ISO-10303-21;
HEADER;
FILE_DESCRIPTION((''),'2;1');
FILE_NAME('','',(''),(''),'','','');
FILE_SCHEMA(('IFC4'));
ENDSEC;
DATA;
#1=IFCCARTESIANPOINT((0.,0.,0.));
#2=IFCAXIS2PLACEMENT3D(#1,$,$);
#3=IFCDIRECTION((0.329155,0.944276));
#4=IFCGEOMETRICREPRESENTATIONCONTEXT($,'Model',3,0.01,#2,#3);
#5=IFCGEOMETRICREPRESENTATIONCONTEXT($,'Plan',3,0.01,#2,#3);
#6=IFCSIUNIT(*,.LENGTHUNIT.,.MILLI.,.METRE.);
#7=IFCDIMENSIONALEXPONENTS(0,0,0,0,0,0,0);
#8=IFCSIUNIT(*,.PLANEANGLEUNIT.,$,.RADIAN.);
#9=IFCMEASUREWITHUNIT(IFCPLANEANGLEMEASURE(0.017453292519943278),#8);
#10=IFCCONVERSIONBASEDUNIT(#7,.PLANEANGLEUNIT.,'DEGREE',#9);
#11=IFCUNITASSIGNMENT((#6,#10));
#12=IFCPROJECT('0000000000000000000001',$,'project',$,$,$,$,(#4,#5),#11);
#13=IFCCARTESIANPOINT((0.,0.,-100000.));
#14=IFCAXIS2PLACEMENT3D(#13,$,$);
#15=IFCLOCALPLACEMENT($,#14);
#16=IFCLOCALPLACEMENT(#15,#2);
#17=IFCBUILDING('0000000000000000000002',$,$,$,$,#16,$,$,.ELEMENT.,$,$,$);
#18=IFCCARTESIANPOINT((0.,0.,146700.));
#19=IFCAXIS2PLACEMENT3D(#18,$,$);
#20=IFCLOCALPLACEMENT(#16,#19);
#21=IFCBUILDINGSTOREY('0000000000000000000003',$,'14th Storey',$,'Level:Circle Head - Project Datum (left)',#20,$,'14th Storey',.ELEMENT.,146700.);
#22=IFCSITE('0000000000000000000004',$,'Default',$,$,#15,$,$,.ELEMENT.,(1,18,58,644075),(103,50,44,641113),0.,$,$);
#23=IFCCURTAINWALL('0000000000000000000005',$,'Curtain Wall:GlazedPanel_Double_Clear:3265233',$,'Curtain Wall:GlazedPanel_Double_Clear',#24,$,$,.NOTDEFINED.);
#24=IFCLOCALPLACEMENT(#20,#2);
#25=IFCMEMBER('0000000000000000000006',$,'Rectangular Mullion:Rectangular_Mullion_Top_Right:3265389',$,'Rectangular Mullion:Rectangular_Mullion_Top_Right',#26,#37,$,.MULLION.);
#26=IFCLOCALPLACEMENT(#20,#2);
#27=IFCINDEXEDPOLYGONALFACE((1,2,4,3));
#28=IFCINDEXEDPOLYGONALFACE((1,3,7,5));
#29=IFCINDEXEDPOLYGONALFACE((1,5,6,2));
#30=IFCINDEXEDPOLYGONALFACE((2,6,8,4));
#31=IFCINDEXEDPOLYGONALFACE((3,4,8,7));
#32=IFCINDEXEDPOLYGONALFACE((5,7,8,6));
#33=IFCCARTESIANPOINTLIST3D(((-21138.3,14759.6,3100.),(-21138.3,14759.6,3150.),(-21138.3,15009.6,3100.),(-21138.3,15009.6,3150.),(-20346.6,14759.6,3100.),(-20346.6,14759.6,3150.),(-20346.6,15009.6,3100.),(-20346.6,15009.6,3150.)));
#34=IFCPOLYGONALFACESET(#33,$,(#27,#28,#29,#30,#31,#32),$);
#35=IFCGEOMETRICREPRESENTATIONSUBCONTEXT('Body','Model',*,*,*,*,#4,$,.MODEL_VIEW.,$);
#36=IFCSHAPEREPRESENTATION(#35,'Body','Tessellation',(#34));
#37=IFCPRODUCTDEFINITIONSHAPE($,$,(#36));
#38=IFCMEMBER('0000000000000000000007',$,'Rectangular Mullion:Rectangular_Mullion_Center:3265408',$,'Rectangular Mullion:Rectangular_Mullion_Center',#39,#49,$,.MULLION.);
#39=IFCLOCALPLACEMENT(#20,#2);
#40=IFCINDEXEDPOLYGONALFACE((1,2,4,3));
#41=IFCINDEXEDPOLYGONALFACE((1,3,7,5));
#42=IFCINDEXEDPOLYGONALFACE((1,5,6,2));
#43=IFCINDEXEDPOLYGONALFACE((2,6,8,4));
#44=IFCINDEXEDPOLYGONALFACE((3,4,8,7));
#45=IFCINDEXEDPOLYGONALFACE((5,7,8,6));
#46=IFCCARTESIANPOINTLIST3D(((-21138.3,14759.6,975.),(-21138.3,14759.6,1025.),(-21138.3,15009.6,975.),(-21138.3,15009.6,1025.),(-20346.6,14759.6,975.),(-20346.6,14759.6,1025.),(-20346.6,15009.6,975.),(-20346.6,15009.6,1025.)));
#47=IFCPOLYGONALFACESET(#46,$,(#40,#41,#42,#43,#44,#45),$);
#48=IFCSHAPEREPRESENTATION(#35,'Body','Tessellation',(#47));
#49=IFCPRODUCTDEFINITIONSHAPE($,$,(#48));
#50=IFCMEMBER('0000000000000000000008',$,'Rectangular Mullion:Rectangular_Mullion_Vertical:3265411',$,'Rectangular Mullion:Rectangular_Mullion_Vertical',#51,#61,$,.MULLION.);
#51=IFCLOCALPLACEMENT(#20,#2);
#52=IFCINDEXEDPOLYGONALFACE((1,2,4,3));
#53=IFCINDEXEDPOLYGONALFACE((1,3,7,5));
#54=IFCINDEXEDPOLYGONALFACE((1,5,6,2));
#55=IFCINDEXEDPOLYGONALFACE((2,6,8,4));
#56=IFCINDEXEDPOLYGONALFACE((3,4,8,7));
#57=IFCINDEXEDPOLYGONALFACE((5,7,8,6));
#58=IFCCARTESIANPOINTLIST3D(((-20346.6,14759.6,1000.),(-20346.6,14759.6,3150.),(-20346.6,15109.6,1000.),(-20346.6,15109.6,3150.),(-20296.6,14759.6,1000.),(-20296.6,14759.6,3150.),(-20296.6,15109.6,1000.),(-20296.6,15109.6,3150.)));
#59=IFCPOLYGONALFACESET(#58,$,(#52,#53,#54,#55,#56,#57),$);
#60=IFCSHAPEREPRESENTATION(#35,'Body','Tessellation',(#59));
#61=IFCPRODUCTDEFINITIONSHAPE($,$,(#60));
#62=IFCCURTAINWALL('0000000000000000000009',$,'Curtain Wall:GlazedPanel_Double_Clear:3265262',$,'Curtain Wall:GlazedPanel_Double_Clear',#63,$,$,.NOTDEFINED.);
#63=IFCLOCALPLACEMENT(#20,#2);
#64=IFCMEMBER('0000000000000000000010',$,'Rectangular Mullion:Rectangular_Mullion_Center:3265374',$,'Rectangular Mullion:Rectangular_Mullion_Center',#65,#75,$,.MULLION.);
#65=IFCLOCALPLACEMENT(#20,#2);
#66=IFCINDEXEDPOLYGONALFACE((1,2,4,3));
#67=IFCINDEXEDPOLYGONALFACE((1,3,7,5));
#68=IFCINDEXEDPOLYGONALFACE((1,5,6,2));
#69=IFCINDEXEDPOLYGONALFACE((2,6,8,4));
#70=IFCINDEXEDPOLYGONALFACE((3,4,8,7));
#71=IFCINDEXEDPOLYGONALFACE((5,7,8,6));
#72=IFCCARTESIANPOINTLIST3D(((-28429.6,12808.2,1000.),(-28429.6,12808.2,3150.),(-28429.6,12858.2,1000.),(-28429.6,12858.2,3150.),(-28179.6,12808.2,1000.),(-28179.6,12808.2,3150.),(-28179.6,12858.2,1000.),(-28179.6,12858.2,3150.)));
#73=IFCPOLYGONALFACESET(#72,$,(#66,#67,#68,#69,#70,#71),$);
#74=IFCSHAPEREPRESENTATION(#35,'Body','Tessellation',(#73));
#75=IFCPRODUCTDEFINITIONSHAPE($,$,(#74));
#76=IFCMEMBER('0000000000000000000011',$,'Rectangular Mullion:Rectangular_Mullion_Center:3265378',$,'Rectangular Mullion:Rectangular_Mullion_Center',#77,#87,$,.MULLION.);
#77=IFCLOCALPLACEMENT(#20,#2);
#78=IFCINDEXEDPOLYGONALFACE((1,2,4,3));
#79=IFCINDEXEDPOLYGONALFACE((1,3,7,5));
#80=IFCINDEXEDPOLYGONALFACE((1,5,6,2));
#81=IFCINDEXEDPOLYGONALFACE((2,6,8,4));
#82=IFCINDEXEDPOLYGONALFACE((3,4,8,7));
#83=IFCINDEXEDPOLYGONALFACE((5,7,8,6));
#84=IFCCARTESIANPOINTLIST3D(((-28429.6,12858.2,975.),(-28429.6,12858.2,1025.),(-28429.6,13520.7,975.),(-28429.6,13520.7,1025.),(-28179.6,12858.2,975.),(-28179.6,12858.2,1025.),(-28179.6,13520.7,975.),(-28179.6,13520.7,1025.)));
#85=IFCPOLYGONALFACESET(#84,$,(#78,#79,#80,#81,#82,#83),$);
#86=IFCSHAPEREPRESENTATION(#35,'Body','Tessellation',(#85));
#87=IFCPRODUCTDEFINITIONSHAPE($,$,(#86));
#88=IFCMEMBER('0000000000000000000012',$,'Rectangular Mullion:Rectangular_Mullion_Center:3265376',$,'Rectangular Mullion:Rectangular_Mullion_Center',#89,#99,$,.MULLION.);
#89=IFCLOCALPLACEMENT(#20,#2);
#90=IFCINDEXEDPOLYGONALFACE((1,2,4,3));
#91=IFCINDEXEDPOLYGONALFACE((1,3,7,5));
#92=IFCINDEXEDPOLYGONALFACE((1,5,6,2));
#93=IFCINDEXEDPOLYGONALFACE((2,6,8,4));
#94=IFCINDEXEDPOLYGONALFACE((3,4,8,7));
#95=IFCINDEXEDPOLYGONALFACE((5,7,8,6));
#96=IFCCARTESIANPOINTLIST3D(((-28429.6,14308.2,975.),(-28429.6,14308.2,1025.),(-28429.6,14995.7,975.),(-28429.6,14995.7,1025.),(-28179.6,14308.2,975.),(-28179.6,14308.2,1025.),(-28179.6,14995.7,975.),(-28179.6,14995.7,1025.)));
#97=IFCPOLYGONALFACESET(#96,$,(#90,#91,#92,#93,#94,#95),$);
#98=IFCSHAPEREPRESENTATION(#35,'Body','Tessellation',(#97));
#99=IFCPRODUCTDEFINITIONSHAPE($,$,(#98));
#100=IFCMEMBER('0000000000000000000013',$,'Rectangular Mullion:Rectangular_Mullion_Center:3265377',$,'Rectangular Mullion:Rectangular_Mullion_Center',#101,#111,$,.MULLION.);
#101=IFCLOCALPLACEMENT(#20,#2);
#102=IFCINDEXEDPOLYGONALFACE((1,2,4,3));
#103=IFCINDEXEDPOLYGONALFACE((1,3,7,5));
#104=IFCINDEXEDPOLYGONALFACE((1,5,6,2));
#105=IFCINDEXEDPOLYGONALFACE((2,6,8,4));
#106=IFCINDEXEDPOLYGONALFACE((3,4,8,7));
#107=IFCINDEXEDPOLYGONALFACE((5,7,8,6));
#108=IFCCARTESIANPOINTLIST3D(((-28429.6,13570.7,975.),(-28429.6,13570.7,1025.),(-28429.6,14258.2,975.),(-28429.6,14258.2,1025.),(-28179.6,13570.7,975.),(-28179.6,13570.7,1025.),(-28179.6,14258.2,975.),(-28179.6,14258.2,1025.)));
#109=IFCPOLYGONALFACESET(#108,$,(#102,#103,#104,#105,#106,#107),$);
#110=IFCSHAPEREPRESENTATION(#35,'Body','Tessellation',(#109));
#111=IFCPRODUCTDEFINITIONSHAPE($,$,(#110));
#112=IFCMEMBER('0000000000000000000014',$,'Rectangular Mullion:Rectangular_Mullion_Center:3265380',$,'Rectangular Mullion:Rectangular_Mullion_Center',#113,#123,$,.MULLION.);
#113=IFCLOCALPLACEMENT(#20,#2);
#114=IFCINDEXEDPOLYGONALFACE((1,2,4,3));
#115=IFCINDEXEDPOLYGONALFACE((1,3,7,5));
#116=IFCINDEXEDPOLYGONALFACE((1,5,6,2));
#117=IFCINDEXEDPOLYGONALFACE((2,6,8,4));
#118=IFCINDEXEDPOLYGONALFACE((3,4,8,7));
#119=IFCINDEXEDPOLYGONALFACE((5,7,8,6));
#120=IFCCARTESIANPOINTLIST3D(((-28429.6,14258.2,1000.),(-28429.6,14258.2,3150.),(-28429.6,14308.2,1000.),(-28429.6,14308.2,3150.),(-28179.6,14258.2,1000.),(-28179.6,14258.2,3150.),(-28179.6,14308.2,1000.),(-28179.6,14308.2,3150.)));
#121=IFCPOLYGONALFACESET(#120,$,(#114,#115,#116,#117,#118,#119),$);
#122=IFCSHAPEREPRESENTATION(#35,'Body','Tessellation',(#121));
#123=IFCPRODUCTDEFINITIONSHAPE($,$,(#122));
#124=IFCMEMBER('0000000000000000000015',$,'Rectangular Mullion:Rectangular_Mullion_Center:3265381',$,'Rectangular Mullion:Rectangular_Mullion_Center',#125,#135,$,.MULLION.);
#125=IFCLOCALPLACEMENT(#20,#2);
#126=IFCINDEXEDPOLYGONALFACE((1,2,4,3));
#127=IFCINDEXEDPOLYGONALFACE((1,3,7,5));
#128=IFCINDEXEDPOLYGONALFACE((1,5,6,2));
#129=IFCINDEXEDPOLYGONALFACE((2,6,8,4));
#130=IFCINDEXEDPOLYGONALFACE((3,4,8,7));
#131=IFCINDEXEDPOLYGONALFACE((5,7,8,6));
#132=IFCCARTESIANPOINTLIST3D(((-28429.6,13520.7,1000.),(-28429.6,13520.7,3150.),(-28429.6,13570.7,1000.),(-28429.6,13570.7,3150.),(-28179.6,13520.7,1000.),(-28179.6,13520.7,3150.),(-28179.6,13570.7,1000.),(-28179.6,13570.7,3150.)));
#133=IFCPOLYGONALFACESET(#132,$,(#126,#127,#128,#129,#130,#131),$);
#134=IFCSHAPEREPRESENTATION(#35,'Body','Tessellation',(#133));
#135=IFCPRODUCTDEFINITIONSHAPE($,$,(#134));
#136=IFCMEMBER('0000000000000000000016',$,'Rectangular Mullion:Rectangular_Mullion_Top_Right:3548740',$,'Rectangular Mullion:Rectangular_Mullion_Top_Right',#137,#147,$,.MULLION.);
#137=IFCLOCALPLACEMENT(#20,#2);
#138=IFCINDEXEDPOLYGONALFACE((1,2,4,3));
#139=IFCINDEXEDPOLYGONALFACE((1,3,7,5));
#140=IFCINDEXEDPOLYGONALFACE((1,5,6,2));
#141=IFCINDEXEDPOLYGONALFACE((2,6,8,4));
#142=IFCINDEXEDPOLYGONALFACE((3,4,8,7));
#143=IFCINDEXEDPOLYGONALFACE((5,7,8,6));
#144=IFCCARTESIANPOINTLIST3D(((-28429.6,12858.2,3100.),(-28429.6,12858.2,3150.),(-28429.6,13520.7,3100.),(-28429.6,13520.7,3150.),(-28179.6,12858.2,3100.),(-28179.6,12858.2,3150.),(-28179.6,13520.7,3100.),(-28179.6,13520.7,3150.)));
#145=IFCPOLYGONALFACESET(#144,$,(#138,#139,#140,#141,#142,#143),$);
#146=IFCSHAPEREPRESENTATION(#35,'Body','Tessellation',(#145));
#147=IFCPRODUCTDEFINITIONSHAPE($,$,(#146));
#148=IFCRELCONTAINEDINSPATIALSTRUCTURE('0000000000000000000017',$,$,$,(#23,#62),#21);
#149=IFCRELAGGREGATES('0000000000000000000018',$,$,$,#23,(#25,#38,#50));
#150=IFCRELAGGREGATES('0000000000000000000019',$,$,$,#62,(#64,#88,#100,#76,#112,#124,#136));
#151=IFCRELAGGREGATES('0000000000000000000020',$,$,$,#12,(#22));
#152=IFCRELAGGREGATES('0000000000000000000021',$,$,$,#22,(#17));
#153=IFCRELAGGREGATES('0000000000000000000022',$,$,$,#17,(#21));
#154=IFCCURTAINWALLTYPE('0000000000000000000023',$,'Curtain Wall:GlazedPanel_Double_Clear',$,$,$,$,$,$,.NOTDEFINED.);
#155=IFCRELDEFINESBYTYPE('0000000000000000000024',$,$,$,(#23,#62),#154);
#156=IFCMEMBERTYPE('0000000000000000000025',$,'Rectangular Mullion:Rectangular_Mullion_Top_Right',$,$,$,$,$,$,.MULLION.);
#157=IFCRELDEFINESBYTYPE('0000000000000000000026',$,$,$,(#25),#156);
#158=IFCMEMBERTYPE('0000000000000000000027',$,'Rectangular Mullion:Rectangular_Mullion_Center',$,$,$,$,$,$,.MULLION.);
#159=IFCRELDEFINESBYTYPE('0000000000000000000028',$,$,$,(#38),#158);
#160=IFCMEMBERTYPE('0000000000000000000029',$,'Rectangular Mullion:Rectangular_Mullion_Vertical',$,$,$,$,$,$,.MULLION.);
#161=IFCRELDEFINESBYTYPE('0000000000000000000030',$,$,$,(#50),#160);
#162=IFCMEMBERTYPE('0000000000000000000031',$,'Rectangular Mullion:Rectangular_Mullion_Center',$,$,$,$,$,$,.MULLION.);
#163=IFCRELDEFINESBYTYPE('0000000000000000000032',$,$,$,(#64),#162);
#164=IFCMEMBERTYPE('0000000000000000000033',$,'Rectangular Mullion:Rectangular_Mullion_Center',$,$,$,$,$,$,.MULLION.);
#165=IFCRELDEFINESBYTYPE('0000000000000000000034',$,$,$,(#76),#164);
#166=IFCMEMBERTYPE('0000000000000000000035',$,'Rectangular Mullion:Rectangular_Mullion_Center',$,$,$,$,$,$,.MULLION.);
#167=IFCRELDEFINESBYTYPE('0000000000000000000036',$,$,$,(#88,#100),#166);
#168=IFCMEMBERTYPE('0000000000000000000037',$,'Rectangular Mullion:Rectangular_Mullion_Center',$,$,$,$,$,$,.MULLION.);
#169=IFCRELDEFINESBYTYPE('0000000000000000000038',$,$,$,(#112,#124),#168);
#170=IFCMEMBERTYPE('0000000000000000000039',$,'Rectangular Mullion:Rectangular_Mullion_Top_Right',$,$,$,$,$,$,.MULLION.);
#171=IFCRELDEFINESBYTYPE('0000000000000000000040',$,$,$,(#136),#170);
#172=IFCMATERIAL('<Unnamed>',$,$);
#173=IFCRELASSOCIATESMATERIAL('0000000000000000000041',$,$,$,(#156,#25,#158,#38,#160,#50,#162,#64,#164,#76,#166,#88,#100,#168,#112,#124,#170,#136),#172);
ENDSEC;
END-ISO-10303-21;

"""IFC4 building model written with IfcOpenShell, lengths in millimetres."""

from ifc_helpers import new_model, entity, si_unit, converted_unit, direction, frame, origin, place, context, subcontext, project, spatial, indexed_curve, outline, extrude, source, transform, mapped, material, type_object, type_shapes, element, aggregate, save


model = new_model("IFC4")

# Units and contexts
model_context = context("Model", 3, precision=0.01, world=origin(), true_north=direction((0.329155, 0.944276)))
plan_context = context("Plan", 3, precision=0.01, world=origin(), true_north=direction((0.329155, 0.944276)))
body_context = subcontext(model_context, "Body", "Model", "MODEL_VIEW")
ifc_project = project(units=[si_unit("LENGTHUNIT", "METRE", prefix="MILLI"), converted_unit("PLANEANGLEUNIT", "DEGREE", entity("IfcPlaneAngleMeasure", 0.017453292519943278), si_unit("PLANEANGLEUNIT", "RADIAN"), dimensions=[0, 0, 0, 0, 0, 0, 0])], contexts=[model_context, plan_context])

# Site, building, storey
site_placement = place(None, frame((0.0, 0.0, -100000.0)))
site = spatial("IfcSite", under=ifc_project, at=site_placement, Name="Default", CompositionType="ELEMENT", RefLatitude=(1, 18, 58, 644075), RefLongitude=(103, 50, 44, 641113), RefElevation=0.0)
building_placement = place(site_placement, origin())
building = spatial("IfcBuilding", under=site, at=building_placement, CompositionType="ELEMENT")
storey_placement = place(building_placement, frame((0.0, 0.0, 146700.0)))
storey = spatial("IfcBuildingStorey", under=building, at=storey_placement, Name="14th Storey", ObjectType="Level:Circle Head - Project Datum (left)", LongName="14th Storey", CompositionType="ELEMENT", Elevation=146700.0)

# Curtain walls, members
curtain_wall_type = type_object("IfcCurtainWallType", Name="Curtain Wall:GlazedPanel_Double_Clear", PredefinedType="NOTDEFINED")
curtain_wall_1_placement = place(storey_placement, frame((0.0, 0.0, -146700.0)))
curtain_wall_1 = element("IfcCurtainWall", 1, at=curtain_wall_1_placement, inside=storey, type_object=curtain_wall_type, Name="Curtain Wall:GlazedPanel_Double_Clear:3265233", ObjectType="Curtain Wall:GlazedPanel_Double_Clear", PredefinedType="NOTDEFINED")
ifc_material_1 = material(Name="<Unnamed>")
member_type_1 = type_object("IfcMemberType", Name="Rectangular Mullion:Rectangular_Mullion_Top_Right", PredefinedType="MULLION", material=ifc_material_1)
shared_shape_1 = source(origin(), body_context, "Body", "SweptSolid", [
    extrude(outline(indexed_curve([(-25.0, -125.0), (25.0, -125.0), (25.0, 125.0), (-25.0, 125.0), (-25.0, -125.0)], self_intersect=False)), frame((-25.0, 0.0, -791.6), z_axis=(0.0, 0.0, 1.0), x_axis=(-1.0, 0.0, 0.0)), (0.0, 0.0, 1.0), 791.6),
])
type_shapes(member_type_1, [shared_shape_1])
member_1_placement = place(curtain_wall_1_placement, frame((-20346.6, 14884.6, 149850.0), z_axis=(1.0, 0.0, 0.0), x_axis=(0.0, 0.0, 1.0)))
member_1 = element("IfcMember", 2, at=member_1_placement, type_object=member_type_1, material=ifc_material_1, Name="Rectangular Mullion:Rectangular_Mullion_Top_Right:3265389", ObjectType="Rectangular Mullion:Rectangular_Mullion_Top_Right", PredefinedType="MULLION", context=body_context, shape_type="MappedRepresentation", body=[
    mapped(shared_shape_1, transform((0.0, 0.0, 0.0), scale=1.0)),
])
member_type_2 = type_object("IfcMemberType", Name="Rectangular Mullion:Rectangular_Mullion_Center", PredefinedType="MULLION", material=ifc_material_1)
shared_shape_2 = source(origin(), body_context, "Body", "SweptSolid", [
    extrude(outline(indexed_curve([(-25.0, -125.0), (25.0, -125.0), (25.0, 125.0), (-25.0, 125.0), (-25.0, -125.0)], self_intersect=False)), frame((0.0, 0.0, -791.7), z_axis=(0.0, 0.0, 1.0), x_axis=(-1.0, 0.0, 0.0)), (0.0, 0.0, 1.0), 791.7),
])
type_shapes(member_type_2, [shared_shape_2])
member_2_placement = place(curtain_wall_1_placement, frame((-20346.6, 14884.6, 147700.0), z_axis=(1.0, 0.0, 0.0), x_axis=(0.0, 0.0, 1.0)))
member_2 = element("IfcMember", 3, at=member_2_placement, type_object=member_type_2, material=ifc_material_1, Name="Rectangular Mullion:Rectangular_Mullion_Center:3265408", ObjectType="Rectangular Mullion:Rectangular_Mullion_Center", PredefinedType="MULLION", context=body_context, shape_type="MappedRepresentation", body=[
    mapped(shared_shape_2, transform((0.0, 0.0, 0.0), scale=1.0)),
])
member_type_3 = type_object("IfcMemberType", Name="Rectangular Mullion:Rectangular_Mullion_Vertical", PredefinedType="MULLION", material=ifc_material_1)
shared_shape_3 = source(origin(), body_context, "Body", "SweptSolid", [
    extrude(outline(indexed_curve([(-25.0, -175.0), (25.0, -175.0), (25.0, 175.0), (-25.0, 175.0), (-25.0, -175.0)], self_intersect=False)), frame((0.0, -50.0, -2150.0), z_axis=(0.0, 0.0, 1.0), x_axis=(-1.0, 0.0, 0.0)), (0.0, 0.0, 1.0), 2150.0),
])
type_shapes(member_type_3, [shared_shape_3])
member_3_placement = place(curtain_wall_1_placement, frame((-20321.6, 14884.6, 147700.0), z_axis=(0.0, 0.0, -1.0), x_axis=(1.0, 0.0, 0.0)))
member_3 = element("IfcMember", 4, at=member_3_placement, type_object=member_type_3, material=ifc_material_1, Name="Rectangular Mullion:Rectangular_Mullion_Vertical:3265411", ObjectType="Rectangular Mullion:Rectangular_Mullion_Vertical", PredefinedType="MULLION", context=body_context, shape_type="MappedRepresentation", body=[
    mapped(shared_shape_3, transform((0.0, 0.0, 0.0), scale=1.0)),
])
aggregate(curtain_wall_1, [member_1, member_2, member_3])
curtain_wall_2_placement = place(storey_placement, frame((0.0, 0.0, -146700.0)))
curtain_wall_2 = element("IfcCurtainWall", 5, at=curtain_wall_2_placement, inside=storey, type_object=curtain_wall_type, Name="Curtain Wall:GlazedPanel_Double_Clear:3265262", ObjectType="Curtain Wall:GlazedPanel_Double_Clear", PredefinedType="NOTDEFINED")
member_type_4 = type_object("IfcMemberType", Name="Rectangular Mullion:Rectangular_Mullion_Center", PredefinedType="MULLION", material=ifc_material_1)
shared_shape_4 = source(origin(), body_context, "Body", "SweptSolid", [
    extrude(outline(indexed_curve([(-25.0, -125.0), (25.0, -125.0), (25.0, 125.0), (-25.0, 125.0), (-25.0, -125.0)], self_intersect=False)), frame((-25.0, 0.0, -2150.0), z_axis=(0.0, 0.0, 1.0), x_axis=(-1.0, 0.0, 0.0)), (0.0, 0.0, 1.0), 2150.0),
])
type_shapes(member_type_4, [shared_shape_4])
member_4_placement = place(curtain_wall_2_placement, frame((-28304.6, 12808.2, 147700.0), z_axis=(0.0, 0.0, -1.0), x_axis=(0.0, -1.0, 0.0)))
member_4 = element("IfcMember", 6, at=member_4_placement, type_object=member_type_4, material=ifc_material_1, Name="Rectangular Mullion:Rectangular_Mullion_Center:3265374", ObjectType="Rectangular Mullion:Rectangular_Mullion_Center", PredefinedType="MULLION", context=body_context, shape_type="MappedRepresentation", body=[
    mapped(shared_shape_4, transform((0.0, 0.0, 0.0), scale=1.0)),
])
member_type_5 = type_object("IfcMemberType", Name="Rectangular Mullion:Rectangular_Mullion_Center", PredefinedType="MULLION", material=ifc_material_1)
shared_shape_5 = source(origin(), body_context, "Body", "SweptSolid", [
    extrude(outline(indexed_curve([(-25.0, -125.0), (25.0, -125.0), (25.0, 125.0), (-25.0, 125.0), (-25.0, -125.0)], self_intersect=False)), frame((0.0, 0.0, -662.5), z_axis=(0.0, 0.0, 1.0), x_axis=(-1.0, 0.0, 0.0)), (0.0, 0.0, 1.0), 662.5),
])
type_shapes(member_type_5, [shared_shape_5])
member_5_placement = place(curtain_wall_2_placement, frame((-28304.6, 12858.2, 147700.0), z_axis=(0.0, -1.0, 0.0), x_axis=(0.0, 0.0, 1.0)))
member_5 = element("IfcMember", 7, at=member_5_placement, type_object=member_type_5, material=ifc_material_1, Name="Rectangular Mullion:Rectangular_Mullion_Center:3265378", ObjectType="Rectangular Mullion:Rectangular_Mullion_Center", PredefinedType="MULLION", context=body_context, shape_type="MappedRepresentation", body=[
    mapped(shared_shape_5, transform((0.0, 0.0, 0.0), scale=1.0)),
])
member_type_6 = type_object("IfcMemberType", Name="Rectangular Mullion:Rectangular_Mullion_Center", PredefinedType="MULLION", material=ifc_material_1)
shared_shape_6 = source(origin(), body_context, "Body", "SweptSolid", [
    extrude(outline(indexed_curve([(-25.0, -125.0), (25.0, -125.0), (25.0, 125.0), (-25.0, 125.0), (-25.0, -125.0)], self_intersect=False)), frame((0.0, 0.0, -687.5), z_axis=(0.0, 0.0, 1.0), x_axis=(-1.0, 0.0, 0.0)), (0.0, 0.0, 1.0), 687.5),
])
type_shapes(member_type_6, [shared_shape_6])
member_6_placement = place(curtain_wall_2_placement, frame((-28304.6, 14308.2, 147700.0), z_axis=(0.0, -1.0, 0.0), x_axis=(0.0, 0.0, 1.0)))
member_6 = element("IfcMember", 8, at=member_6_placement, type_object=member_type_6, material=ifc_material_1, Name="Rectangular Mullion:Rectangular_Mullion_Center:3265376", ObjectType="Rectangular Mullion:Rectangular_Mullion_Center", PredefinedType="MULLION", context=body_context, shape_type="MappedRepresentation", body=[
    mapped(shared_shape_6, transform((0.0, 0.0, 0.0), scale=1.0)),
])
member_7_placement = place(curtain_wall_2_placement, frame((-28304.6, 13570.7, 147700.0), z_axis=(0.0, -1.0, 0.0), x_axis=(0.0, 0.0, 1.0)))
member_7 = element("IfcMember", 9, at=member_7_placement, type_object=member_type_6, material=ifc_material_1, Name="Rectangular Mullion:Rectangular_Mullion_Center:3265377", ObjectType="Rectangular Mullion:Rectangular_Mullion_Center", PredefinedType="MULLION", context=body_context, shape_type="MappedRepresentation", body=[
    mapped(shared_shape_6, transform((0.0, 0.0, 0.0), scale=1.0)),
])
member_type_7 = type_object("IfcMemberType", Name="Rectangular Mullion:Rectangular_Mullion_Center", PredefinedType="MULLION", material=ifc_material_1)
shared_shape_7 = source(origin(), body_context, "Body", "SweptSolid", [
    extrude(outline(indexed_curve([(-25.0, -125.0), (25.0, -125.0), (25.0, 125.0), (-25.0, 125.0), (-25.0, -125.0)], self_intersect=False)), frame((0.0, 0.0, -2150.0), z_axis=(0.0, 0.0, 1.0), x_axis=(-1.0, 0.0, 0.0)), (0.0, 0.0, 1.0), 2150.0),
])
type_shapes(member_type_7, [shared_shape_7])
member_8_placement = place(curtain_wall_2_placement, frame((-28304.6, 14283.2, 147700.0), z_axis=(0.0, 0.0, -1.0), x_axis=(0.0, -1.0, 0.0)))
member_8 = element("IfcMember", 10, at=member_8_placement, type_object=member_type_7, material=ifc_material_1, Name="Rectangular Mullion:Rectangular_Mullion_Center:3265380", ObjectType="Rectangular Mullion:Rectangular_Mullion_Center", PredefinedType="MULLION", context=body_context, shape_type="MappedRepresentation", body=[
    mapped(shared_shape_7, transform((0.0, 0.0, 0.0), scale=1.0)),
])
member_9_placement = place(curtain_wall_2_placement, frame((-28304.6, 13545.7, 147700.0), z_axis=(0.0, 0.0, -1.0), x_axis=(0.0, -1.0, 0.0)))
member_9 = element("IfcMember", 11, at=member_9_placement, type_object=member_type_7, material=ifc_material_1, Name="Rectangular Mullion:Rectangular_Mullion_Center:3265381", ObjectType="Rectangular Mullion:Rectangular_Mullion_Center", PredefinedType="MULLION", context=body_context, shape_type="MappedRepresentation", body=[
    mapped(shared_shape_7, transform((0.0, 0.0, 0.0), scale=1.0)),
])
member_type_8 = type_object("IfcMemberType", Name="Rectangular Mullion:Rectangular_Mullion_Top_Right", PredefinedType="MULLION", material=ifc_material_1)
shared_shape_8 = source(origin(), body_context, "Body", "SweptSolid", [
    extrude(outline(indexed_curve([(-25.0, -125.0), (25.0, -125.0), (25.0, 125.0), (-25.0, 125.0), (-25.0, -125.0)], self_intersect=False)), frame((-25.0, 0.0, -662.5), z_axis=(0.0, 0.0, 1.0), x_axis=(-1.0, 0.0, 0.0)), (0.0, 0.0, 1.0), 662.5),
])
type_shapes(member_type_8, [shared_shape_8])
member_10_placement = place(curtain_wall_2_placement, frame((-28304.6, 12858.2, 149850.0), z_axis=(0.0, -1.0, 0.0), x_axis=(0.0, 0.0, 1.0)))
member_10 = element("IfcMember", 12, at=member_10_placement, type_object=member_type_8, material=ifc_material_1, Name="Rectangular Mullion:Rectangular_Mullion_Top_Right:3548740", ObjectType="Rectangular Mullion:Rectangular_Mullion_Top_Right", PredefinedType="MULLION", context=body_context, shape_type="MappedRepresentation", body=[
    mapped(shared_shape_8, transform((0.0, 0.0, 0.0), scale=1.0)),
])

aggregate(curtain_wall_2, [member_4, member_6, member_7, member_5, member_8, member_9, member_10])

save(model, "model.ifc")
